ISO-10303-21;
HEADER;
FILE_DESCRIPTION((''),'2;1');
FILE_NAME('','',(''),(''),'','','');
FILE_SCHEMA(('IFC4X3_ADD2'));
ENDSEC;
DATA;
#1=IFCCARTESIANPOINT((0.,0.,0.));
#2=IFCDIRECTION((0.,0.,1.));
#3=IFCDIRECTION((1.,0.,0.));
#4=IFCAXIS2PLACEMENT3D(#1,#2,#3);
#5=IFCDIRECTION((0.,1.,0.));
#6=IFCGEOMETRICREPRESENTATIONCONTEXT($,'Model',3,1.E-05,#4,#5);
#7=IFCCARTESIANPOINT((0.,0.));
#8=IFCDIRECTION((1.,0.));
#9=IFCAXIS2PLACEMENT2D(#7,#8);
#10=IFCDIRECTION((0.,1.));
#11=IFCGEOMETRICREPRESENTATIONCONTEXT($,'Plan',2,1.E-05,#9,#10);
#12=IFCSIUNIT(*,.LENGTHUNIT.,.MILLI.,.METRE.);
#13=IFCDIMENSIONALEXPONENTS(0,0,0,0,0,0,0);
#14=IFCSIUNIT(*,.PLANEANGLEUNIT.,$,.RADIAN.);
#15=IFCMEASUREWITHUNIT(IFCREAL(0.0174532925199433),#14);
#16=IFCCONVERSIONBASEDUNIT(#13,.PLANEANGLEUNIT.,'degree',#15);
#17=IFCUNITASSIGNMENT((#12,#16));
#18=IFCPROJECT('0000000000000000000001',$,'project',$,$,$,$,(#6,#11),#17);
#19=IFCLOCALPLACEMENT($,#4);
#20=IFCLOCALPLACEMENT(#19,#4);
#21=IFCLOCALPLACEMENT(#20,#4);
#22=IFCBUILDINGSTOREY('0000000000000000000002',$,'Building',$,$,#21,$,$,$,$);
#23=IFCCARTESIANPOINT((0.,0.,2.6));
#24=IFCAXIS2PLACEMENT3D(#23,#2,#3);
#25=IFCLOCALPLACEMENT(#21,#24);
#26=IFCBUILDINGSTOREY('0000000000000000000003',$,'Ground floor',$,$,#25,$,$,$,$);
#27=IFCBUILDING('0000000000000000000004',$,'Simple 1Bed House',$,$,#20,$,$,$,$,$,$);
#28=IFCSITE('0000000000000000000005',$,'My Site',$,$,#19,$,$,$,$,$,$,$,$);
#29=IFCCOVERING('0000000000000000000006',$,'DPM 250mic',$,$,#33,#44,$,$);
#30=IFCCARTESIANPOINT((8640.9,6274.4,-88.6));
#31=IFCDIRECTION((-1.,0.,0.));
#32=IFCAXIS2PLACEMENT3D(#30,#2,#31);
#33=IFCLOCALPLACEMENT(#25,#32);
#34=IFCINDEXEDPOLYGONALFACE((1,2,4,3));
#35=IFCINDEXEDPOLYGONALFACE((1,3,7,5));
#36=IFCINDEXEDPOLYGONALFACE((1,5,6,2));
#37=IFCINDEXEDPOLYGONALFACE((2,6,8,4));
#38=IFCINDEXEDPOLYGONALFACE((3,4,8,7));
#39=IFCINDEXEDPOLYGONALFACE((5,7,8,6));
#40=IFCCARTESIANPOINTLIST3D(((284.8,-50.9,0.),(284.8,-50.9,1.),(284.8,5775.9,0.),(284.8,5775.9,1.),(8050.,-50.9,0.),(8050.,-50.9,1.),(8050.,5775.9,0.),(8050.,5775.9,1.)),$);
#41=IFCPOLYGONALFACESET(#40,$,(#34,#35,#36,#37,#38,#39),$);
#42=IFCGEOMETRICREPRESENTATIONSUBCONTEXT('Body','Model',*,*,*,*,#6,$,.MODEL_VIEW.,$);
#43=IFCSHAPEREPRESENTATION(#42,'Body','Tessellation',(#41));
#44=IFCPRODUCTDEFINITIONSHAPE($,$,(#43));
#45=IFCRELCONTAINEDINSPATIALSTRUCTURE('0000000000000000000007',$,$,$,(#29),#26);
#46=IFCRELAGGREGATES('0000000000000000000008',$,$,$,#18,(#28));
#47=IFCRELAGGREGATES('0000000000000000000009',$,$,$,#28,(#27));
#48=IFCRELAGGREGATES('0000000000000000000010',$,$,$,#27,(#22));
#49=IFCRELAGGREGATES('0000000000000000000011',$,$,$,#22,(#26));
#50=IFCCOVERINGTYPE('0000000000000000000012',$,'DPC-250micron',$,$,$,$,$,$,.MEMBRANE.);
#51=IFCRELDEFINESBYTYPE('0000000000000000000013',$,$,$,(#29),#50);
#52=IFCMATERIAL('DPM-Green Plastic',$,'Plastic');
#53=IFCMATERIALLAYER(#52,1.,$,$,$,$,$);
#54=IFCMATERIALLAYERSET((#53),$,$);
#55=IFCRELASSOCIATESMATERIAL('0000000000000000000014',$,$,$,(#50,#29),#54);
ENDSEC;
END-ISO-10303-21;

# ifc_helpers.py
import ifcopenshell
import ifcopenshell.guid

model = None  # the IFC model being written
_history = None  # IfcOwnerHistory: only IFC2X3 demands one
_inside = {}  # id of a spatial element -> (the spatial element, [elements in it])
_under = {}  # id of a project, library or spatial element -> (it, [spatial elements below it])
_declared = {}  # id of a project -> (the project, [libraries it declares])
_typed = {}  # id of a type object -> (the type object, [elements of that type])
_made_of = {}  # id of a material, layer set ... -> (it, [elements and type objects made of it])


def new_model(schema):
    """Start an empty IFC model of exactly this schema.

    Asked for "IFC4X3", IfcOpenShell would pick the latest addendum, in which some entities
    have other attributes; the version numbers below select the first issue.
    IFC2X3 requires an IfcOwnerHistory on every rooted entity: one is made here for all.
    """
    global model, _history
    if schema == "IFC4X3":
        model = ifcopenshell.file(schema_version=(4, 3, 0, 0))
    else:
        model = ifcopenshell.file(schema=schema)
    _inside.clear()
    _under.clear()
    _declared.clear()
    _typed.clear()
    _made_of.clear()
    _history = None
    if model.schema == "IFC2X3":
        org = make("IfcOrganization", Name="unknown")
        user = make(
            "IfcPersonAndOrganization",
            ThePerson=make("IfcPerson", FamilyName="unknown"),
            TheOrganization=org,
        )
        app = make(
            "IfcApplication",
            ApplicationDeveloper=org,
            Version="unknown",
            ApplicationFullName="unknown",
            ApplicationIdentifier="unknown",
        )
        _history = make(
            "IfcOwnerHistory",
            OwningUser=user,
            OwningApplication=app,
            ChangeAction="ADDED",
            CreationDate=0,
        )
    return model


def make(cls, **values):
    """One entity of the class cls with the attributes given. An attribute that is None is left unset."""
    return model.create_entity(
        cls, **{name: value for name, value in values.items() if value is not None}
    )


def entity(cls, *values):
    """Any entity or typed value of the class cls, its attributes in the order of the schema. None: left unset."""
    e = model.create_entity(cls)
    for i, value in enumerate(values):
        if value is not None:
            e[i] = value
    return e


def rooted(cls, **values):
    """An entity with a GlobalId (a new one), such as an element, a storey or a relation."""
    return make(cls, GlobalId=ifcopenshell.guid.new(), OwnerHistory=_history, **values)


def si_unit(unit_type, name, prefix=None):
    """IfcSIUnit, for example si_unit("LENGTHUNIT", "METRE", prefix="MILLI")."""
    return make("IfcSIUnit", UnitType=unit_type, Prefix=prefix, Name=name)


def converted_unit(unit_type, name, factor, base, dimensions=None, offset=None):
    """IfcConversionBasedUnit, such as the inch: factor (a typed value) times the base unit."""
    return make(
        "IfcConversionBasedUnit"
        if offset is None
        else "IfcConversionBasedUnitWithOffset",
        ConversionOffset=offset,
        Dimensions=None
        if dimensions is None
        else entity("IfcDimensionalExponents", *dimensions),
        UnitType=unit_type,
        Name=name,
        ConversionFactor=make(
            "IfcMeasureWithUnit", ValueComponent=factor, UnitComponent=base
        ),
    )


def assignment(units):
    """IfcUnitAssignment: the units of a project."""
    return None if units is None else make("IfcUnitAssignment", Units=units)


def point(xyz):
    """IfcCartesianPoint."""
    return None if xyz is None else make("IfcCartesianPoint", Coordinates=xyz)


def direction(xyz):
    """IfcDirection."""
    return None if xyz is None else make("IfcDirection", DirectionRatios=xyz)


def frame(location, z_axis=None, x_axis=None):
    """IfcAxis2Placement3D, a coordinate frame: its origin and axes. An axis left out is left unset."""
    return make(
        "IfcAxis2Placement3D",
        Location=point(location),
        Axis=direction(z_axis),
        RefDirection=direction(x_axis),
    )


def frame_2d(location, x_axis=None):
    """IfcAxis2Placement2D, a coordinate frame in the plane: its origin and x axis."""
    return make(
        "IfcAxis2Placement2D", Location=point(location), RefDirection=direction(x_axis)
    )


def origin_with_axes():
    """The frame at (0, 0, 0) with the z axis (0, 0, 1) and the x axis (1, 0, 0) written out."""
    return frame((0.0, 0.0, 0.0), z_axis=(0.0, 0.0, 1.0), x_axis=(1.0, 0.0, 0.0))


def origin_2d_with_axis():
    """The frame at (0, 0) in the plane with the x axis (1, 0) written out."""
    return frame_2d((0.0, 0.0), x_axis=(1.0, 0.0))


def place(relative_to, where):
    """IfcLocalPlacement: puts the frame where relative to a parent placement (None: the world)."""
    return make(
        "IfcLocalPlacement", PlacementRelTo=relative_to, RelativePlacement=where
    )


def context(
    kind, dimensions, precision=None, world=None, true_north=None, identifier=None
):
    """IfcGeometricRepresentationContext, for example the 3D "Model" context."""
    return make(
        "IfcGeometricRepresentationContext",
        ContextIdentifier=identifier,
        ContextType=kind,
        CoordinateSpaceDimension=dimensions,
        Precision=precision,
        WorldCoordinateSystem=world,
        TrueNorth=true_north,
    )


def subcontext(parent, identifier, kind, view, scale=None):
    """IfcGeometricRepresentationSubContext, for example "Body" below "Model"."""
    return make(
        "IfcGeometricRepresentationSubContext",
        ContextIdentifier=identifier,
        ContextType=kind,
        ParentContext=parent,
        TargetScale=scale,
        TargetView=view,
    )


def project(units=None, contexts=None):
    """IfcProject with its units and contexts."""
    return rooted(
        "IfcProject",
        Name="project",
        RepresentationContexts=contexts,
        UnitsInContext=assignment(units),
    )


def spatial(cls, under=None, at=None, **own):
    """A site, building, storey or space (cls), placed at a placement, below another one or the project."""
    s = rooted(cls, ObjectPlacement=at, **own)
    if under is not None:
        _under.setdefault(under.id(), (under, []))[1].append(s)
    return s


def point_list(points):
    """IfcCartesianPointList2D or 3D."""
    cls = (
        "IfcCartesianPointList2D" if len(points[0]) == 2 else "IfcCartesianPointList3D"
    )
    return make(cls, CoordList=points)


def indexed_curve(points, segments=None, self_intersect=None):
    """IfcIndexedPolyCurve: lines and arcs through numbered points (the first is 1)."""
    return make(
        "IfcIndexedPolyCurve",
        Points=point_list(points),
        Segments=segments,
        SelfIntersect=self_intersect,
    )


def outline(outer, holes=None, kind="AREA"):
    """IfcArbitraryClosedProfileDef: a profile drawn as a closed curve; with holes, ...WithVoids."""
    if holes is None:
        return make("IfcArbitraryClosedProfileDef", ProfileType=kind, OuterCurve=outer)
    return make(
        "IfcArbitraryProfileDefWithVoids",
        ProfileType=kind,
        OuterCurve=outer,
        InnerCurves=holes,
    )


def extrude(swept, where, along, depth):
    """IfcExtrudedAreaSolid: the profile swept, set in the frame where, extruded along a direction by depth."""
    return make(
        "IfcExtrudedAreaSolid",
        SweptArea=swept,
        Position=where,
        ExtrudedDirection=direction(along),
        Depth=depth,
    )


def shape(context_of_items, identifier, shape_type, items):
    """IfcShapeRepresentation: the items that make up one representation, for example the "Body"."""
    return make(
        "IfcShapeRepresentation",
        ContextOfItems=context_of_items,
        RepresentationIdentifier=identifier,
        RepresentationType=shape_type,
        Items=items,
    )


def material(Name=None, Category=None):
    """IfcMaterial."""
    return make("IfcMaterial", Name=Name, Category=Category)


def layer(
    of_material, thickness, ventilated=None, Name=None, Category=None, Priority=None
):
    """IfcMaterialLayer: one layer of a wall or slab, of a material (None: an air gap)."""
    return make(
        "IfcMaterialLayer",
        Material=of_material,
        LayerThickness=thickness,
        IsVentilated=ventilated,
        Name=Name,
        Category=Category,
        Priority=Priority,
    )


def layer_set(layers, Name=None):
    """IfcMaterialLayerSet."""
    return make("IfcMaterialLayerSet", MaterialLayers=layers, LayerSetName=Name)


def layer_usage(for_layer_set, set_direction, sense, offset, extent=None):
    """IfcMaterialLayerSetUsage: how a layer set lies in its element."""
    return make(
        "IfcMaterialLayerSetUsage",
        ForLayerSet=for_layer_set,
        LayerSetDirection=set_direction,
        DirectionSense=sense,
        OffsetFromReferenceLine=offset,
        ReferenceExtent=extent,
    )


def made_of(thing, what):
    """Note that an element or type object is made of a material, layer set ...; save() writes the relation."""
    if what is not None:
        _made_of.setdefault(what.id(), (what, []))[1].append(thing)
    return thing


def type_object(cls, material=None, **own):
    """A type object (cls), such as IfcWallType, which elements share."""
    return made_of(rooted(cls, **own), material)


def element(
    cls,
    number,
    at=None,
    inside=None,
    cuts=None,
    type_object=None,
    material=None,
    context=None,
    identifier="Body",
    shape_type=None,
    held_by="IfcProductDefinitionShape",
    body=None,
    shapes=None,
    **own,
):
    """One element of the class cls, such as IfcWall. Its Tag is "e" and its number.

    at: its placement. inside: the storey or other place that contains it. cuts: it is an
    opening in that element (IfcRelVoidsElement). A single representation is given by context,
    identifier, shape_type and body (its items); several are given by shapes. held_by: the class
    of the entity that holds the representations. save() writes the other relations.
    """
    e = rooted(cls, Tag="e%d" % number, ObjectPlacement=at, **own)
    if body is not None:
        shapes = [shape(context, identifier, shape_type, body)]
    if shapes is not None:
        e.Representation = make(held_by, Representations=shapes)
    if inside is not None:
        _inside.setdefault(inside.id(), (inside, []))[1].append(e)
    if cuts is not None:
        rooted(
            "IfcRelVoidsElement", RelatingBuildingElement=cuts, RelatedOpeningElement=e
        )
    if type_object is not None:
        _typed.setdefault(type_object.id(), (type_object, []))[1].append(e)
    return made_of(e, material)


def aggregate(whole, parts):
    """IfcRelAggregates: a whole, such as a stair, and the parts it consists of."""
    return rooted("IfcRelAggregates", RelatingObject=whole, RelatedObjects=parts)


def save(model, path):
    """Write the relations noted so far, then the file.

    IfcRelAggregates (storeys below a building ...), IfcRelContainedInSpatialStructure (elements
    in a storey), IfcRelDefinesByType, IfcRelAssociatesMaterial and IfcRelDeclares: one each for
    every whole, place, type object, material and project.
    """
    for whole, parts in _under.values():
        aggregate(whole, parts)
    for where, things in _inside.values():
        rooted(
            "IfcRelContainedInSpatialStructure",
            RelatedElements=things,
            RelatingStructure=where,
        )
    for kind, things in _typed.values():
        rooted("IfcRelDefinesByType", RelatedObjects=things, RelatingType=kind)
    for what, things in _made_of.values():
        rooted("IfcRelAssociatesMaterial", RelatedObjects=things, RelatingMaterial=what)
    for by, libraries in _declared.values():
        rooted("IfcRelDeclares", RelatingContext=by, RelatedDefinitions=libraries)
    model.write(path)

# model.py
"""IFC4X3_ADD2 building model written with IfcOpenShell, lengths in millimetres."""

from ifc_helpers import new_model, entity, si_unit, converted_unit, direction, frame, origin_with_axes, origin_2d_with_axis, place, context, subcontext, project, spatial, indexed_curve, outline, extrude, material, layer, layer_set, layer_usage, type_object, element, save


model = new_model("IFC4X3_ADD2")

# Units and contexts
model_context = context("Model", 3, precision=1e-05, world=origin_with_axes(), true_north=direction((0.0, 1.0, 0.0)))
plan_context = context("Plan", 2, precision=1e-05, world=origin_2d_with_axis(), true_north=direction((0.0, 1.0)))
body_context_1 = subcontext(model_context, "Body", "Model", "MODEL_VIEW")
ifc_project = project(units=[si_unit("LENGTHUNIT", "METRE", prefix="MILLI"), converted_unit("PLANEANGLEUNIT", "degree", entity("IfcReal", 0.0174532925199433), si_unit("PLANEANGLEUNIT", "RADIAN"), dimensions=[0, 0, 0, 0, 0, 0, 0])], contexts=[model_context, plan_context])

# Site, building, storeys
site_placement = place(None, origin_with_axes())
site = spatial("IfcSite", under=ifc_project, at=site_placement, Name="My Site")
building_placement = place(site_placement, origin_with_axes())
building = spatial("IfcBuilding", under=site, at=building_placement, Name="Simple 1Bed House")
storey_1_placement = place(building_placement, origin_with_axes())
storey_1 = spatial("IfcBuildingStorey", under=building, at=storey_1_placement, Name="Building")
storey_2_placement = place(storey_1_placement, frame((0.0, 0.0, 2.6), z_axis=(0.0, 0.0, 1.0), x_axis=(1.0, 0.0, 0.0)))
storey_2 = spatial("IfcBuildingStorey", under=storey_1, at=storey_2_placement, Name="Ground floor")

# Covering
ifc_material_1 = material(Name="DPM-Green Plastic", Category="Plastic")
ifc_layer_1 = layer(ifc_material_1, 1.0)
ifc_layer_set_1 = layer_set([ifc_layer_1])
ifc_layer_usage_1 = layer_usage(ifc_layer_set_1, "AXIS3", "POSITIVE", 0.0)
covering_type = type_object("IfcCoveringType", Name="DPC-250micron", PredefinedType="MEMBRANE", material=ifc_layer_set_1)
covering_placement = place(storey_2_placement, frame((8640.9, 6274.4, -88.6), z_axis=(0.0, 0.0, 1.0), x_axis=(-1.0, 0.0, 0.0)))
element("IfcCovering", 1, at=covering_placement, inside=storey_2, type_object=covering_type, material=ifc_layer_usage_1, Name="DPM 250mic", context=body_context_1, shape_type="SweptSolid", body=[
    extrude(outline(indexed_curve([(8050.0, -50.9), (8050.0, 5775.9), (284.8, 5775.9), (284.8, -50.9), (8050.0, -50.9)])), None, (0.0, 0.0, 1.0), 1.0),
])

save(model, "model.ifc")
